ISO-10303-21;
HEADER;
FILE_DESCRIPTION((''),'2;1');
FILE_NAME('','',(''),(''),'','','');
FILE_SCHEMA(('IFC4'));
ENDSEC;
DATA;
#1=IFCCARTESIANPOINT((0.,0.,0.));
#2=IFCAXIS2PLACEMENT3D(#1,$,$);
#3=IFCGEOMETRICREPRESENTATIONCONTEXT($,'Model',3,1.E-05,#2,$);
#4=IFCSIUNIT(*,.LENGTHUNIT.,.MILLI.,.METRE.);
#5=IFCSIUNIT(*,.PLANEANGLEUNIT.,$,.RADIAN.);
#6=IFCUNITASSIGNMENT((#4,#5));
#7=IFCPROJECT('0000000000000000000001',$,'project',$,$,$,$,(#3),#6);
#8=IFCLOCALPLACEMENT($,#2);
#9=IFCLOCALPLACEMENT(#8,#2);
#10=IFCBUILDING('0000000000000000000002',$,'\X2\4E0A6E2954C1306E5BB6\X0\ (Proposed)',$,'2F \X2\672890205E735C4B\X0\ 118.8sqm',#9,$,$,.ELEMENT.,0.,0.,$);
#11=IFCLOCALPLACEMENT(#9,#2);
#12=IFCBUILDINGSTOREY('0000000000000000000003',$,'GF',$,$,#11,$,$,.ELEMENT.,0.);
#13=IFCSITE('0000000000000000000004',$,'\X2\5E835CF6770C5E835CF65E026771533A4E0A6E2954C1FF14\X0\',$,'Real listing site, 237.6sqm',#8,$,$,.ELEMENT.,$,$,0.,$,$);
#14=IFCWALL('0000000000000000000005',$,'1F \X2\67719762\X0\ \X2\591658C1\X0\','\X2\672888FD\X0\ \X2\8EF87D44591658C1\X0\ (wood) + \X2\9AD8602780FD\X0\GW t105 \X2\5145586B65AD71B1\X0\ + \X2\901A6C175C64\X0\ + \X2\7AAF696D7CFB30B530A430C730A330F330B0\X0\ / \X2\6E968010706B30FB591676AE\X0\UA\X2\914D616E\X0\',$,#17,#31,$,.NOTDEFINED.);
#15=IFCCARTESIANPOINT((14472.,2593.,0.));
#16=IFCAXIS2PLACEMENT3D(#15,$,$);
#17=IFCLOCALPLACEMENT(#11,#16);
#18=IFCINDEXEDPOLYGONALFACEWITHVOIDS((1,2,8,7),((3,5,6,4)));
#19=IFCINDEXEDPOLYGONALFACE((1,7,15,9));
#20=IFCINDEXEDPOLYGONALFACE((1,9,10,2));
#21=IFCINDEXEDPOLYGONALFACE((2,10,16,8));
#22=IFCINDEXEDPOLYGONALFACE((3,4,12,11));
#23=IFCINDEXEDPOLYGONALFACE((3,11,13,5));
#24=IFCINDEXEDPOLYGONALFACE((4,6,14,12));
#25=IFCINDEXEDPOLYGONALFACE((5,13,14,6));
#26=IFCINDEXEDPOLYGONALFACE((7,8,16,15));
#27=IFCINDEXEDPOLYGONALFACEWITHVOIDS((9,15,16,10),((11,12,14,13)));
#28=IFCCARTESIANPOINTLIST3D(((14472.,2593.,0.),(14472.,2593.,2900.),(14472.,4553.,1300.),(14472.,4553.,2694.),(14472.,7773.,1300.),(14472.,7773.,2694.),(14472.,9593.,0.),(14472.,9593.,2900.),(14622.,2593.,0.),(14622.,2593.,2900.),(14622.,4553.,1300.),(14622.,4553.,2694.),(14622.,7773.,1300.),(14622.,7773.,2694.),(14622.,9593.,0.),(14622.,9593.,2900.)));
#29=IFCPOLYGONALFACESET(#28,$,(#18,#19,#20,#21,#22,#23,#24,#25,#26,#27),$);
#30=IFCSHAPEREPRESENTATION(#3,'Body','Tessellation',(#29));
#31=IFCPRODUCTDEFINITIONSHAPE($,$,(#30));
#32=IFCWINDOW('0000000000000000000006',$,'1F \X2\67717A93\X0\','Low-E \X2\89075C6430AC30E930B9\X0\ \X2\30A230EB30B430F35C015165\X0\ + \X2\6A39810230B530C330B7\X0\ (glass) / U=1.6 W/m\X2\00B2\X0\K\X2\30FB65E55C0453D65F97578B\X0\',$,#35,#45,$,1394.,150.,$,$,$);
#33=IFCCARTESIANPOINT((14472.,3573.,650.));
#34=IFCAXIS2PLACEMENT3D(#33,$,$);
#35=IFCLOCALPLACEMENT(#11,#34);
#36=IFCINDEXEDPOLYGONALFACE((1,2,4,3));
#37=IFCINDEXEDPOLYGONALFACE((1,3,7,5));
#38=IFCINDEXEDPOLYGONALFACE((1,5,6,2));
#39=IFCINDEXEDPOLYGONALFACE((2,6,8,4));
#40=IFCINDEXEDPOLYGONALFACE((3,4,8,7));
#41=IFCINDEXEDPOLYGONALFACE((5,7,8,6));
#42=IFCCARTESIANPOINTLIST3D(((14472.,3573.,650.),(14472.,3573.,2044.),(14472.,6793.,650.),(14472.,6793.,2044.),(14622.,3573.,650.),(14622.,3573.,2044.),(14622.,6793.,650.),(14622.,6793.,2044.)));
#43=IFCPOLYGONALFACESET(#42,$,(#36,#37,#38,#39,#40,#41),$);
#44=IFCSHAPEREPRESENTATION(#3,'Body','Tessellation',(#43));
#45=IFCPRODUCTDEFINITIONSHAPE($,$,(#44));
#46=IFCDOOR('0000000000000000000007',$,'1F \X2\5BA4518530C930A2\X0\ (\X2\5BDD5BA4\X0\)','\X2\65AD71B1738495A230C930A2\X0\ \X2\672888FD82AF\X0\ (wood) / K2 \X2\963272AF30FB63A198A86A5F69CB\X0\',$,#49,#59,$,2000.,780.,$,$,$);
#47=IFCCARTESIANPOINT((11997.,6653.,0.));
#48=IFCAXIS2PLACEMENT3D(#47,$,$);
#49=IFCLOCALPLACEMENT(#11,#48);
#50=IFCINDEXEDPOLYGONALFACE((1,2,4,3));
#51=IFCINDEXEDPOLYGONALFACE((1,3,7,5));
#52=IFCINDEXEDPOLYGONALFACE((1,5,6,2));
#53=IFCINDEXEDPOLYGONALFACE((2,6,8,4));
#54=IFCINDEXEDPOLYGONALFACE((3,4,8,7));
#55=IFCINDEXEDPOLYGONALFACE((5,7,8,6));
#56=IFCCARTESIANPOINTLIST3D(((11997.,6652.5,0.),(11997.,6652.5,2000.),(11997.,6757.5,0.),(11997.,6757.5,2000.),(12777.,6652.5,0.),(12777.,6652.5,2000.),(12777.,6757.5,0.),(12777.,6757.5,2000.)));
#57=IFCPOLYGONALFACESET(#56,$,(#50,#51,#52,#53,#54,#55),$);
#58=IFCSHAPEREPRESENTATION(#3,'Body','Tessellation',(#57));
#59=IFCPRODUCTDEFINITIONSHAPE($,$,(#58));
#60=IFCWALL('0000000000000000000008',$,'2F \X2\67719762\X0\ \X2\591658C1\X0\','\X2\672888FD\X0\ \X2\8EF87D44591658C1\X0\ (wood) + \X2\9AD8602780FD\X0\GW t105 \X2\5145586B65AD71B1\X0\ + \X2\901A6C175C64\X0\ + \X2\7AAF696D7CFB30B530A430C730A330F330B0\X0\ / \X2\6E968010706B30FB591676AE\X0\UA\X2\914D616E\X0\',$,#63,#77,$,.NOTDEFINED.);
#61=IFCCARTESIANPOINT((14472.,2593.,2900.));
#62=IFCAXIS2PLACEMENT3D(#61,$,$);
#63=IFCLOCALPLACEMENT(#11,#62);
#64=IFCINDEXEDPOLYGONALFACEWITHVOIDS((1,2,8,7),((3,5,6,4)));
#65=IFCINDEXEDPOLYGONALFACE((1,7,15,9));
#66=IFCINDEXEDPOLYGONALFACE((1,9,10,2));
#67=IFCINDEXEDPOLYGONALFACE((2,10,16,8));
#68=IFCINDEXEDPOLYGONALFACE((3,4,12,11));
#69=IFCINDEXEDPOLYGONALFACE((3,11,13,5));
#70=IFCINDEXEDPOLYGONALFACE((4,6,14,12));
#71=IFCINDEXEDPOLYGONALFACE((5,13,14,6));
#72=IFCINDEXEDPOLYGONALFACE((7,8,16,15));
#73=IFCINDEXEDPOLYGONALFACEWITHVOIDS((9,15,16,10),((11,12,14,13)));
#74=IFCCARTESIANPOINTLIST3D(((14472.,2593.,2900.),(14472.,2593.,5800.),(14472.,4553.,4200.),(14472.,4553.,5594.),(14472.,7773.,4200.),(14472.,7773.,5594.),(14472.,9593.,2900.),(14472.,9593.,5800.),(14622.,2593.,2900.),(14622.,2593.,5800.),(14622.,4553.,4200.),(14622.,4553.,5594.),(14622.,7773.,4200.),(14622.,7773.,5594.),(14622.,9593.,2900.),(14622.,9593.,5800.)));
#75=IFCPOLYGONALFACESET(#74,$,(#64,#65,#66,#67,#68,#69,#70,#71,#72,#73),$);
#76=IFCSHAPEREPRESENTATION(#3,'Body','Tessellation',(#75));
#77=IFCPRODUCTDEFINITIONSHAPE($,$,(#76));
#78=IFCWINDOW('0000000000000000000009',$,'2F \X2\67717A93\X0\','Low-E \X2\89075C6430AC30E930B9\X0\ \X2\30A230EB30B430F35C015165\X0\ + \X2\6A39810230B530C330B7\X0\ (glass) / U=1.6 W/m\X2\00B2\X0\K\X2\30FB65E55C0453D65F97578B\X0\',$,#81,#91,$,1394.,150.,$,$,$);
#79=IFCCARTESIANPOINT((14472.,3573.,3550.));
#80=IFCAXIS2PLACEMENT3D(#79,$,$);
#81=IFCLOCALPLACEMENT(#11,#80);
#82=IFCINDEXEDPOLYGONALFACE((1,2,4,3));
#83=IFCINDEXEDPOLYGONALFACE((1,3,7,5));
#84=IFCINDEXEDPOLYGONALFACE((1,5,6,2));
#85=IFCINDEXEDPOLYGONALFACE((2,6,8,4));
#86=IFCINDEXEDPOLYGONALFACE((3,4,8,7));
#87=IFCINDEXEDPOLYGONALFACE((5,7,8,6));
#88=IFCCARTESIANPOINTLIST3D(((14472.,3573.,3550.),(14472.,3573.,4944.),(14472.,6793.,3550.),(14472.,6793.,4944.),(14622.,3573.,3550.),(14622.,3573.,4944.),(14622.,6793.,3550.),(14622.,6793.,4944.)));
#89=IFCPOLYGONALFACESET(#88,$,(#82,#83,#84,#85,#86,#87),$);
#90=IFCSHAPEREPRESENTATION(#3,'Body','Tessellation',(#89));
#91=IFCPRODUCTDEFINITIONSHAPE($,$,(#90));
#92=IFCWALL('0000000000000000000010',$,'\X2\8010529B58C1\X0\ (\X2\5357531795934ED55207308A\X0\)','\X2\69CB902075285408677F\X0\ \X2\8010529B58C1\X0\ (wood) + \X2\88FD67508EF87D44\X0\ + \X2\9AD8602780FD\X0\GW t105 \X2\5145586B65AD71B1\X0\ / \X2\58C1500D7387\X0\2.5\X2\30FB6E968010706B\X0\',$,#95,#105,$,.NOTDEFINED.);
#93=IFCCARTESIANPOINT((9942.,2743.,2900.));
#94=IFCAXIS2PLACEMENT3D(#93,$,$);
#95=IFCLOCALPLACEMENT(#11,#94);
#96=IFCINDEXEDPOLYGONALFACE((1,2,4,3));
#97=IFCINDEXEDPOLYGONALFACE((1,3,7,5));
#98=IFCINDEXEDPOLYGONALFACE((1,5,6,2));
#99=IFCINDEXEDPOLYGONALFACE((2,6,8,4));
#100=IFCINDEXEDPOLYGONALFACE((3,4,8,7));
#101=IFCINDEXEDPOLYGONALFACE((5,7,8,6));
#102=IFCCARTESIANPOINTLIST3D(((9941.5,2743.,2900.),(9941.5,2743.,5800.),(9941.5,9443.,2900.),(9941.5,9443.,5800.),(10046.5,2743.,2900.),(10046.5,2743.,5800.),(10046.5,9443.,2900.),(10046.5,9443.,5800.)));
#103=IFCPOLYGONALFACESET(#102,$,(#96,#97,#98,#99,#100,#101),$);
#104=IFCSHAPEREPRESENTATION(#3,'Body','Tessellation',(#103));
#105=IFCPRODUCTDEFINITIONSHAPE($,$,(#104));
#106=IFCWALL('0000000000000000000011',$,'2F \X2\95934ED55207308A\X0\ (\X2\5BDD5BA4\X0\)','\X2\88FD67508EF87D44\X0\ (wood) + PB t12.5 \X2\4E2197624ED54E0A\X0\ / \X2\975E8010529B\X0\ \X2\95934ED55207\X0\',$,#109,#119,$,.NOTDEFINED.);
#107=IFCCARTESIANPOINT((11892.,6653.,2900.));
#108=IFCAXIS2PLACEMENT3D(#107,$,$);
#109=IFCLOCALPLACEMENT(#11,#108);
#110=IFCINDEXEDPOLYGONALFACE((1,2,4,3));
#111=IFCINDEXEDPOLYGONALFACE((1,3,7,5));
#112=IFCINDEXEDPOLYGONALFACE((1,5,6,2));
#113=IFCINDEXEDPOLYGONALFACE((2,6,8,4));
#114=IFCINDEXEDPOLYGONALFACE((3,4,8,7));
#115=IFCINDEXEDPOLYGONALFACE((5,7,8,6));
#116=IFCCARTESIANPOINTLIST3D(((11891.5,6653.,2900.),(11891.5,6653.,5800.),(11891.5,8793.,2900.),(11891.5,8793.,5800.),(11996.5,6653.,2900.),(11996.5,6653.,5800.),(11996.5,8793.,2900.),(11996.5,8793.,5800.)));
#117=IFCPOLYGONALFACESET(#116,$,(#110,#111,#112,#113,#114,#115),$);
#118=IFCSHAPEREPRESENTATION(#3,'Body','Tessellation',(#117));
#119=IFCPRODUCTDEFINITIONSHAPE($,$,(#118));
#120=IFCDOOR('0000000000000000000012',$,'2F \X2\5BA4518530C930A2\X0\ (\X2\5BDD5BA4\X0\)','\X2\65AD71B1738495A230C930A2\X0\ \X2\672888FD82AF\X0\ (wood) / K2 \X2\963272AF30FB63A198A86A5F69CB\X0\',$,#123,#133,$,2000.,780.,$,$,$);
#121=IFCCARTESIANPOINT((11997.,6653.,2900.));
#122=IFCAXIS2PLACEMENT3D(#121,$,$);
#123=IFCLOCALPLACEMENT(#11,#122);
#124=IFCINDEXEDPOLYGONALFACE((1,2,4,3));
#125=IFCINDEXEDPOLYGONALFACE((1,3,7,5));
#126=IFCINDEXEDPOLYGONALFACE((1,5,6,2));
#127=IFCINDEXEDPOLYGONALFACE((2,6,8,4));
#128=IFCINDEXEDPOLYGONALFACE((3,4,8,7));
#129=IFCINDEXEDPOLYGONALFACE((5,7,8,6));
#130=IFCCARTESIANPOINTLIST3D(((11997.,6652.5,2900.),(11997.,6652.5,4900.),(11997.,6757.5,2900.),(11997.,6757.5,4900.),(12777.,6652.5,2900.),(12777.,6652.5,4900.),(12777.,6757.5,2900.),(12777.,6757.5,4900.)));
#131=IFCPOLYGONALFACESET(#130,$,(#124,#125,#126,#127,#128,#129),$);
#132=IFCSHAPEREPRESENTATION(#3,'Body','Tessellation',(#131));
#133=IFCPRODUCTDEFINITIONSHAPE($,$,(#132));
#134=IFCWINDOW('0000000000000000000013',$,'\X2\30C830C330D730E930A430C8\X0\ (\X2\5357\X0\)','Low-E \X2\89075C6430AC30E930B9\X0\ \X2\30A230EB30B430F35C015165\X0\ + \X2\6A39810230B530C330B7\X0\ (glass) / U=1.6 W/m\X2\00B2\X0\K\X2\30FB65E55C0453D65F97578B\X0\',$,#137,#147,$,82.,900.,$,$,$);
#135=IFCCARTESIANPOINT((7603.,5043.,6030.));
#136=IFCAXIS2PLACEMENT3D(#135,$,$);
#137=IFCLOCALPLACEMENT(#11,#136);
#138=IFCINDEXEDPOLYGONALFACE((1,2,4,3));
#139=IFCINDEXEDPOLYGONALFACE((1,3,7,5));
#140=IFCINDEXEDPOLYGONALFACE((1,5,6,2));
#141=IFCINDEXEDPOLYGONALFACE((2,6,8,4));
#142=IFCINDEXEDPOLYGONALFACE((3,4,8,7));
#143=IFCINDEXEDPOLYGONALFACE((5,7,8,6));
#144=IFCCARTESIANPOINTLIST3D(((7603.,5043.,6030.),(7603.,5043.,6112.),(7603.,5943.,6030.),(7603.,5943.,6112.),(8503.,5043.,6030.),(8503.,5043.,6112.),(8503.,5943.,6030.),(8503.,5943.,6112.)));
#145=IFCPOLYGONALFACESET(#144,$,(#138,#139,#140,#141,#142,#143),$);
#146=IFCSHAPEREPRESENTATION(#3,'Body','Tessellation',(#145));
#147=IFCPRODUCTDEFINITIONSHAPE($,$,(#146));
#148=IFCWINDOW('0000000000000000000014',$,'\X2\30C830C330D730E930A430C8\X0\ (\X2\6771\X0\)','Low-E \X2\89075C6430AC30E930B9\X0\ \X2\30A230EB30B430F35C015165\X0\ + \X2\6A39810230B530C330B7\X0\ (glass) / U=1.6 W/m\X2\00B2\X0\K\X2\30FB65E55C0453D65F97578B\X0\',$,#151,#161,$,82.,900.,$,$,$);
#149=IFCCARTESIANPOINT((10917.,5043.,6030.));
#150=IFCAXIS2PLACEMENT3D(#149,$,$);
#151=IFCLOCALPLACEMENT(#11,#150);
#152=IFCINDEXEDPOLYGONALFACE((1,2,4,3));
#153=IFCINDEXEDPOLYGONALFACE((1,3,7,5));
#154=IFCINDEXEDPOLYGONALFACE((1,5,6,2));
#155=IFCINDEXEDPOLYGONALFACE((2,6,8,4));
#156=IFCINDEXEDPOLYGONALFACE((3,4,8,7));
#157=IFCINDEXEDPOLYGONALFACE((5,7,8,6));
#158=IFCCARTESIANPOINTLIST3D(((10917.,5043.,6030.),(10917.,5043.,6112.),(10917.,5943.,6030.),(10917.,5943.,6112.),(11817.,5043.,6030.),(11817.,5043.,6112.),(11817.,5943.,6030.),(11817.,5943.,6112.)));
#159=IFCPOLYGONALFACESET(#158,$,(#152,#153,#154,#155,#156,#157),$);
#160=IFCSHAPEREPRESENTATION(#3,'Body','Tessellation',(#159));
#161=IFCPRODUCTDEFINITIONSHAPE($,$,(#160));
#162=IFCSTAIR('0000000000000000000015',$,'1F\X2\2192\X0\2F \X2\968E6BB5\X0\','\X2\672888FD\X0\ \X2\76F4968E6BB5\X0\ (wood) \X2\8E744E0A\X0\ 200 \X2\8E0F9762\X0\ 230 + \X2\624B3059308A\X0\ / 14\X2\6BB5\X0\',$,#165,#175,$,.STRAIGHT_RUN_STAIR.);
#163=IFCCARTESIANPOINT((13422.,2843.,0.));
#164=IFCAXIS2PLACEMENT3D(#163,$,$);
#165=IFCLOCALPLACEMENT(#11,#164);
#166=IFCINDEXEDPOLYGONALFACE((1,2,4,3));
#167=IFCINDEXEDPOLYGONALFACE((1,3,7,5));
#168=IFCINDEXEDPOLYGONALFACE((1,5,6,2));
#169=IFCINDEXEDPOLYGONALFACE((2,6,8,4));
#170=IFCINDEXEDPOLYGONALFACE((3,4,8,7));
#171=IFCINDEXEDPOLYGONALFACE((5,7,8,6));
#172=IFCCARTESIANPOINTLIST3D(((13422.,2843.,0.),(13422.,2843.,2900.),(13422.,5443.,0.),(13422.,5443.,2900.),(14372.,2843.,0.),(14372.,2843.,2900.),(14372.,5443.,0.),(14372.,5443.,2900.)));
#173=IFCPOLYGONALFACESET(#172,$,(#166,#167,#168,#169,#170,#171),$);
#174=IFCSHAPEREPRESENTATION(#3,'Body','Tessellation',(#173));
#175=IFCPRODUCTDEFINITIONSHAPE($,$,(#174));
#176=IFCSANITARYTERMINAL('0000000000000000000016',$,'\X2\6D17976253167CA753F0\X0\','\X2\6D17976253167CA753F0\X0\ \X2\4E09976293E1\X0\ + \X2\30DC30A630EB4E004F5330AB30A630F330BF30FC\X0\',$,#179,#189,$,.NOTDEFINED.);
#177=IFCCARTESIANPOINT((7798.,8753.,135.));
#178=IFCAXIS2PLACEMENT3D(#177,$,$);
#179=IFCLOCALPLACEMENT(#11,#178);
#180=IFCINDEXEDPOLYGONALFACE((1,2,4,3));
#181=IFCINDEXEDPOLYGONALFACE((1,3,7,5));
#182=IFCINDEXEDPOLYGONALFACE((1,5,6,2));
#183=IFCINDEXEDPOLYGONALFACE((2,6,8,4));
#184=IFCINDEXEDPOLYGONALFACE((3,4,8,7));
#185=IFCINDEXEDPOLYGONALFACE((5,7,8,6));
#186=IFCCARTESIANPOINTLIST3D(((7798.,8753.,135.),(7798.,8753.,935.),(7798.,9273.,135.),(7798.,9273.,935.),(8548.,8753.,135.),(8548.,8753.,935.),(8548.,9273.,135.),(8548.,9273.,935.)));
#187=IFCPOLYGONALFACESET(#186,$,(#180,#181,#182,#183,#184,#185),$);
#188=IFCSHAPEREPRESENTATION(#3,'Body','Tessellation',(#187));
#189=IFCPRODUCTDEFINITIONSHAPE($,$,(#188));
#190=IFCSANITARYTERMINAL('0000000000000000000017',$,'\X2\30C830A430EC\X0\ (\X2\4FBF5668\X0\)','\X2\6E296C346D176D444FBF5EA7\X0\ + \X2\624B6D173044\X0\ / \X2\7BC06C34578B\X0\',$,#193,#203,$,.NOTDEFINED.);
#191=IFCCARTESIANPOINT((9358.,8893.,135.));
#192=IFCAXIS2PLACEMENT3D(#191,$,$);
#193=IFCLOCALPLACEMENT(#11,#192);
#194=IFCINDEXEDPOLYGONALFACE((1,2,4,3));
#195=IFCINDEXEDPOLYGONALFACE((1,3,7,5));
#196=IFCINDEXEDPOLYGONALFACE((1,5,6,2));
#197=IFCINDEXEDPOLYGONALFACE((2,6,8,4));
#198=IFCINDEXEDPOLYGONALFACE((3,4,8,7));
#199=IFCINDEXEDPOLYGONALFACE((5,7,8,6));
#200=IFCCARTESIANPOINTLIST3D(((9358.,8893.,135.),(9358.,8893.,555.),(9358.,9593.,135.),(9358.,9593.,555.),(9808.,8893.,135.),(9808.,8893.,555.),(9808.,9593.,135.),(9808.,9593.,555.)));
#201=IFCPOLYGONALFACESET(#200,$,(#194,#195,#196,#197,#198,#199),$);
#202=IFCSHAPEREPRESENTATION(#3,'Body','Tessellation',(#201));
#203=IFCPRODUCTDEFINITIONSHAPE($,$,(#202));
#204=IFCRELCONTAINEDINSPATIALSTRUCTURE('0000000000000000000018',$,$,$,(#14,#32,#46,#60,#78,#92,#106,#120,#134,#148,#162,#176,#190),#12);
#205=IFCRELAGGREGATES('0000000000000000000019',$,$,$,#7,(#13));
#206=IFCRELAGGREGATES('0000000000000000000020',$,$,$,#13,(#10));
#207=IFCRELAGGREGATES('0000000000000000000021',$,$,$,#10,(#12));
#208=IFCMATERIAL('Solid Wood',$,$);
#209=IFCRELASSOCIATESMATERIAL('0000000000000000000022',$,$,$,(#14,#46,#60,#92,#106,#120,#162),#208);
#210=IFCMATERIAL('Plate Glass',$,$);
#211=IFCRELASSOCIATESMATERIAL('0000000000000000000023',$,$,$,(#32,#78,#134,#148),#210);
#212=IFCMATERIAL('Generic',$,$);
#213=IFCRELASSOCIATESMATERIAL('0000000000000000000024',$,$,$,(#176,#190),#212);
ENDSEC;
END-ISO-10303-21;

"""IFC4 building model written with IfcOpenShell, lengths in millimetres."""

from ifc_helpers import new_model, si_unit, frame, frame_2d, origin, place, context, project, spatial, rectangle, extrude, material, element, fill, save


model = new_model("IFC4")

# Units and contexts
model_context = context("Model", 3, precision=1e-05, world=origin())
ifc_project = project(units=[si_unit("LENGTHUNIT", "METRE", prefix="MILLI"), si_unit("PLANEANGLEUNIT", "RADIAN")], contexts=[model_context])

# Site, building, storey
site_placement = place(None, origin())
site = spatial("IfcSite", under=ifc_project, at=site_placement, Name="広島県広島市東区上温品４", ObjectType="Real listing site, 237.6sqm", CompositionType="ELEMENT", RefElevation=0.0)
building_placement = place(site_placement, origin())
building = spatial("IfcBuilding", under=site, at=building_placement, Name="上温品の家 (Proposed)", ObjectType="2F 木造平屋 118.8sqm", CompositionType="ELEMENT", ElevationOfRefHeight=0.0, ElevationOfTerrain=0.0)
storey_placement = place(building_placement, origin())
storey = spatial("IfcBuildingStorey", under=building, at=storey_placement, Name="GF", CompositionType="ELEMENT", Elevation=0.0)

# Wall, opening, window
ifc_material_1 = material(Name="Solid Wood")
wall_1_placement = place(storey_placement, frame((14472.0, 2593.0, 0.0)))
wall_1 = element("IfcWall", 1, at=wall_1_placement, inside=storey, material=ifc_material_1, Name="1F 東面 外壁", Description="木製 軸組外壁 (wood) + 高性能GW t105 充填断熱 + 通気層 + 窯業系サイディング / 準耐火・外皮UA配慮", PredefinedType="NOTDEFINED", context=model_context, shape_type="SweptSolid", body=[
    extrude(rectangle(XDim=150.0, YDim=7000.0, at=frame_2d((75.0, 3500.0))), frame((14472.0, 2593.0, 0.0)), (0.0, 0.0, 1.0), 2900.0),
])
opening_1_placement = place(storey_placement, frame((14472.0, 3573.0, 650.0)))
opening_1 = element("IfcOpeningElement", 2, at=opening_1_placement, cuts=wall_1, PredefinedType="NOTDEFINED", context=model_context, shape_type="SweptSolid", body=[
    extrude(rectangle(XDim=150.0, YDim=3220.0, at=frame_2d((75.0, 1610.0))), frame((14472.0, 3573.0, 650.0)), (0.0, 0.0, 1.0), 1394.0),
])
ifc_material_2 = material(Name="Plate Glass")
window_1_placement = place(storey_placement, frame((14472.0, 3573.0, 650.0)))
window_1 = element("IfcWindow", 3, at=window_1_placement, inside=storey, material=ifc_material_2, Name="1F 東窓", Description="Low-E 複層ガラス アルゴン封入 + 樹脂サッシ (glass) / U=1.6 W/m²K・日射取得型", OverallHeight=1394.0, OverallWidth=150.0, context=model_context, shape_type="SweptSolid", body=[
    extrude(rectangle(XDim=150.0, YDim=3220.0, at=frame_2d((75.0, 1610.0))), frame((14472.0, 3573.0, 650.0)), (0.0, 0.0, 1.0), 1394.0),
])
fill(opening_1, window_1)

# Door
door_1_placement = place(storey_placement, frame((11997.0, 6653.0, 0.0)))
element("IfcDoor", 4, at=door_1_placement, inside=storey, material=ifc_material_1, Name="1F 室内ドア (寝室)", Description="断熱玄関ドア 木製芯 (wood) / K2 防犯・採風機構", OverallHeight=2000.0, OverallWidth=780.0, context=model_context, shape_type="SweptSolid", body=[
    extrude(rectangle(XDim=780.0, YDim=105.0, at=frame_2d((390.0, 52.0))), frame((11997.0, 6653.0, 0.0)), (0.0, 0.0, 1.0), 2000.0),
])

# Wall, opening, window
wall_2_placement = place(storey_placement, frame((14472.0, 2593.0, 2900.0)))
wall_2 = element("IfcWall", 5, at=wall_2_placement, inside=storey, material=ifc_material_1, Name="2F 東面 外壁", Description="木製 軸組外壁 (wood) + 高性能GW t105 充填断熱 + 通気層 + 窯業系サイディング / 準耐火・外皮UA配慮", PredefinedType="NOTDEFINED", context=model_context, shape_type="SweptSolid", body=[
    extrude(rectangle(XDim=150.0, YDim=7000.0, at=frame_2d((75.0, 3500.0))), frame((14472.0, 2593.0, 2900.0)), (0.0, 0.0, 1.0), 2900.0),
])
opening_2_placement = place(storey_placement, frame((14472.0, 3573.0, 3550.0)))
opening_2 = element("IfcOpeningElement", 6, at=opening_2_placement, cuts=wall_2, PredefinedType="NOTDEFINED", context=model_context, shape_type="SweptSolid", body=[
    extrude(rectangle(XDim=150.0, YDim=3220.0, at=frame_2d((75.0, 1610.0))), frame((14472.0, 3573.0, 3550.0)), (0.0, 0.0, 1.0), 1394.0),
])
window_2_placement = place(storey_placement, frame((14472.0, 3573.0, 3550.0)))
window_2 = element("IfcWindow", 7, at=window_2_placement, inside=storey, material=ifc_material_2, Name="2F 東窓", Description="Low-E 複層ガラス アルゴン封入 + 樹脂サッシ (glass) / U=1.6 W/m²K・日射取得型", OverallHeight=1394.0, OverallWidth=150.0, context=model_context, shape_type="SweptSolid", body=[
    extrude(rectangle(XDim=150.0, YDim=3220.0, at=frame_2d((75.0, 1610.0))), frame((14472.0, 3573.0, 3550.0)), (0.0, 0.0, 1.0), 1394.0),
])
fill(opening_2, window_2)

# Walls
wall_3_placement = place(storey_placement, frame((9942.0, 2743.0, 2900.0)))
element("IfcWall", 8, at=wall_3_placement, inside=storey, material=ifc_material_1, Name="耐力壁 (南北間仕切り)", Description="構造用合板 耐力壁 (wood) + 製材軸組 + 高性能GW t105 充填断熱 / 壁倍率2.5・準耐火", PredefinedType="NOTDEFINED", context=model_context, shape_type="SweptSolid", body=[
    extrude(rectangle(XDim=105.0, YDim=6700.0, at=frame_2d((52.0, 3350.0))), frame((9942.0, 2743.0, 2900.0)), (0.0, 0.0, 1.0), 2900.0),
])
wall_4_placement = place(storey_placement, frame((11892.0, 6653.0, 2900.0)))
element("IfcWall", 9, at=wall_4_placement, inside=storey, material=ifc_material_1, Name="2F 間仕切り (寝室)", Description="製材軸組 (wood) + PB t12.5 両面仕上 / 非耐力 間仕切", PredefinedType="NOTDEFINED", context=model_context, shape_type="SweptSolid", body=[
    extrude(rectangle(XDim=105.0, YDim=2140.0, at=frame_2d((52.0, 1070.0))), frame((11892.0, 6653.0, 2900.0)), (0.0, 0.0, 1.0), 2900.0),
])

# Door
door_2_placement = place(storey_placement, frame((11997.0, 6653.0, 2900.0)))
element("IfcDoor", 10, at=door_2_placement, inside=storey, material=ifc_material_1, Name="2F 室内ドア (寝室)", Description="断熱玄関ドア 木製芯 (wood) / K2 防犯・採風機構", OverallHeight=2000.0, OverallWidth=780.0, context=model_context, shape_type="SweptSolid", body=[
    extrude(rectangle(XDim=780.0, YDim=105.0, at=frame_2d((390.0, 52.0))), frame((11997.0, 6653.0, 2900.0)), (0.0, 0.0, 1.0), 2000.0),
])

# Windows
window_3_placement = place(storey_placement, frame((7603.0, 5043.0, 6030.0)))
element("IfcWindow", 11, at=window_3_placement, inside=storey, material=ifc_material_2, Name="トップライト (南)", Description="Low-E 複層ガラス アルゴン封入 + 樹脂サッシ (glass) / U=1.6 W/m²K・日射取得型", OverallHeight=82.0, OverallWidth=900.0, context=model_context, shape_type="SweptSolid", body=[
    extrude(rectangle(XDim=900.0, YDim=900.0, at=frame_2d((450.0, 450.0))), frame((7603.0, 5043.0, 6030.0)), (0.0, 0.0, 1.0), 82.0),
])
window_4_placement = place(storey_placement, frame((10917.0, 5043.0, 6030.0)))
element("IfcWindow", 12, at=window_4_placement, inside=storey, material=ifc_material_2, Name="トップライト (東)", Description="Low-E 複層ガラス アルゴン封入 + 樹脂サッシ (glass) / U=1.6 W/m²K・日射取得型", OverallHeight=82.0, OverallWidth=900.0, context=model_context, shape_type="SweptSolid", body=[
    extrude(rectangle(XDim=900.0, YDim=900.0, at=frame_2d((450.0, 450.0))), frame((10917.0, 5043.0, 6030.0)), (0.0, 0.0, 1.0), 82.0),
])

# Stair
stair_placement = place(storey_placement, frame((13422.0, 2843.0, 0.0)))
element("IfcStair", 13, at=stair_placement, inside=storey, material=ifc_material_1, Name="1F→2F 階段", Description="木製 直階段 (wood) 蹴上 200 踏面 230 + 手すり / 14段", PredefinedType="STRAIGHT_RUN_STAIR", context=model_context, shape_type="SweptSolid", body=[
    extrude(rectangle(XDim=950.0, YDim=2600.0, at=frame_2d((475.0, 1300.0))), frame((13422.0, 2843.0, 0.0)), (0.0, 0.0, 1.0), 2900.0),
])

# Sanitary terminals
ifc_material_3 = material(Name="Generic")
sanitary_terminal_1_placement = place(storey_placement, frame((7798.0, 8753.0, 135.0)))
element("IfcSanitaryTerminal", 14, at=sanitary_terminal_1_placement, inside=storey, material=ifc_material_3, Name="洗面化粧台", Description="洗面化粧台 三面鏡 + ボウル一体カウンター", PredefinedType="NOTDEFINED", context=model_context, shape_type="SweptSolid", body=[
    extrude(rectangle(XDim=750.0, YDim=520.0, at=frame_2d((375.0, 260.0))), frame((7798.0, 8753.0, 135.0)), (0.0, 0.0, 1.0), 800.0),
])
sanitary_terminal_2_placement = place(storey_placement, frame((9358.0, 8893.0, 135.0)))
element("IfcSanitaryTerminal", 15, at=sanitary_terminal_2_placement, inside=storey, material=ifc_material_3, Name="トイレ (便器)", Description="温水洗浄便座 + 手洗い / 節水型", PredefinedType="NOTDEFINED", context=model_context, shape_type="SweptSolid", body=[
    extrude(rectangle(XDim=450.0, YDim=700.0, at=frame_2d((225.0, 350.0))), frame((9358.0, 8893.0, 135.0)), (0.0, 0.0, 1.0), 420.0),
])

save(model, "model.ifc")
